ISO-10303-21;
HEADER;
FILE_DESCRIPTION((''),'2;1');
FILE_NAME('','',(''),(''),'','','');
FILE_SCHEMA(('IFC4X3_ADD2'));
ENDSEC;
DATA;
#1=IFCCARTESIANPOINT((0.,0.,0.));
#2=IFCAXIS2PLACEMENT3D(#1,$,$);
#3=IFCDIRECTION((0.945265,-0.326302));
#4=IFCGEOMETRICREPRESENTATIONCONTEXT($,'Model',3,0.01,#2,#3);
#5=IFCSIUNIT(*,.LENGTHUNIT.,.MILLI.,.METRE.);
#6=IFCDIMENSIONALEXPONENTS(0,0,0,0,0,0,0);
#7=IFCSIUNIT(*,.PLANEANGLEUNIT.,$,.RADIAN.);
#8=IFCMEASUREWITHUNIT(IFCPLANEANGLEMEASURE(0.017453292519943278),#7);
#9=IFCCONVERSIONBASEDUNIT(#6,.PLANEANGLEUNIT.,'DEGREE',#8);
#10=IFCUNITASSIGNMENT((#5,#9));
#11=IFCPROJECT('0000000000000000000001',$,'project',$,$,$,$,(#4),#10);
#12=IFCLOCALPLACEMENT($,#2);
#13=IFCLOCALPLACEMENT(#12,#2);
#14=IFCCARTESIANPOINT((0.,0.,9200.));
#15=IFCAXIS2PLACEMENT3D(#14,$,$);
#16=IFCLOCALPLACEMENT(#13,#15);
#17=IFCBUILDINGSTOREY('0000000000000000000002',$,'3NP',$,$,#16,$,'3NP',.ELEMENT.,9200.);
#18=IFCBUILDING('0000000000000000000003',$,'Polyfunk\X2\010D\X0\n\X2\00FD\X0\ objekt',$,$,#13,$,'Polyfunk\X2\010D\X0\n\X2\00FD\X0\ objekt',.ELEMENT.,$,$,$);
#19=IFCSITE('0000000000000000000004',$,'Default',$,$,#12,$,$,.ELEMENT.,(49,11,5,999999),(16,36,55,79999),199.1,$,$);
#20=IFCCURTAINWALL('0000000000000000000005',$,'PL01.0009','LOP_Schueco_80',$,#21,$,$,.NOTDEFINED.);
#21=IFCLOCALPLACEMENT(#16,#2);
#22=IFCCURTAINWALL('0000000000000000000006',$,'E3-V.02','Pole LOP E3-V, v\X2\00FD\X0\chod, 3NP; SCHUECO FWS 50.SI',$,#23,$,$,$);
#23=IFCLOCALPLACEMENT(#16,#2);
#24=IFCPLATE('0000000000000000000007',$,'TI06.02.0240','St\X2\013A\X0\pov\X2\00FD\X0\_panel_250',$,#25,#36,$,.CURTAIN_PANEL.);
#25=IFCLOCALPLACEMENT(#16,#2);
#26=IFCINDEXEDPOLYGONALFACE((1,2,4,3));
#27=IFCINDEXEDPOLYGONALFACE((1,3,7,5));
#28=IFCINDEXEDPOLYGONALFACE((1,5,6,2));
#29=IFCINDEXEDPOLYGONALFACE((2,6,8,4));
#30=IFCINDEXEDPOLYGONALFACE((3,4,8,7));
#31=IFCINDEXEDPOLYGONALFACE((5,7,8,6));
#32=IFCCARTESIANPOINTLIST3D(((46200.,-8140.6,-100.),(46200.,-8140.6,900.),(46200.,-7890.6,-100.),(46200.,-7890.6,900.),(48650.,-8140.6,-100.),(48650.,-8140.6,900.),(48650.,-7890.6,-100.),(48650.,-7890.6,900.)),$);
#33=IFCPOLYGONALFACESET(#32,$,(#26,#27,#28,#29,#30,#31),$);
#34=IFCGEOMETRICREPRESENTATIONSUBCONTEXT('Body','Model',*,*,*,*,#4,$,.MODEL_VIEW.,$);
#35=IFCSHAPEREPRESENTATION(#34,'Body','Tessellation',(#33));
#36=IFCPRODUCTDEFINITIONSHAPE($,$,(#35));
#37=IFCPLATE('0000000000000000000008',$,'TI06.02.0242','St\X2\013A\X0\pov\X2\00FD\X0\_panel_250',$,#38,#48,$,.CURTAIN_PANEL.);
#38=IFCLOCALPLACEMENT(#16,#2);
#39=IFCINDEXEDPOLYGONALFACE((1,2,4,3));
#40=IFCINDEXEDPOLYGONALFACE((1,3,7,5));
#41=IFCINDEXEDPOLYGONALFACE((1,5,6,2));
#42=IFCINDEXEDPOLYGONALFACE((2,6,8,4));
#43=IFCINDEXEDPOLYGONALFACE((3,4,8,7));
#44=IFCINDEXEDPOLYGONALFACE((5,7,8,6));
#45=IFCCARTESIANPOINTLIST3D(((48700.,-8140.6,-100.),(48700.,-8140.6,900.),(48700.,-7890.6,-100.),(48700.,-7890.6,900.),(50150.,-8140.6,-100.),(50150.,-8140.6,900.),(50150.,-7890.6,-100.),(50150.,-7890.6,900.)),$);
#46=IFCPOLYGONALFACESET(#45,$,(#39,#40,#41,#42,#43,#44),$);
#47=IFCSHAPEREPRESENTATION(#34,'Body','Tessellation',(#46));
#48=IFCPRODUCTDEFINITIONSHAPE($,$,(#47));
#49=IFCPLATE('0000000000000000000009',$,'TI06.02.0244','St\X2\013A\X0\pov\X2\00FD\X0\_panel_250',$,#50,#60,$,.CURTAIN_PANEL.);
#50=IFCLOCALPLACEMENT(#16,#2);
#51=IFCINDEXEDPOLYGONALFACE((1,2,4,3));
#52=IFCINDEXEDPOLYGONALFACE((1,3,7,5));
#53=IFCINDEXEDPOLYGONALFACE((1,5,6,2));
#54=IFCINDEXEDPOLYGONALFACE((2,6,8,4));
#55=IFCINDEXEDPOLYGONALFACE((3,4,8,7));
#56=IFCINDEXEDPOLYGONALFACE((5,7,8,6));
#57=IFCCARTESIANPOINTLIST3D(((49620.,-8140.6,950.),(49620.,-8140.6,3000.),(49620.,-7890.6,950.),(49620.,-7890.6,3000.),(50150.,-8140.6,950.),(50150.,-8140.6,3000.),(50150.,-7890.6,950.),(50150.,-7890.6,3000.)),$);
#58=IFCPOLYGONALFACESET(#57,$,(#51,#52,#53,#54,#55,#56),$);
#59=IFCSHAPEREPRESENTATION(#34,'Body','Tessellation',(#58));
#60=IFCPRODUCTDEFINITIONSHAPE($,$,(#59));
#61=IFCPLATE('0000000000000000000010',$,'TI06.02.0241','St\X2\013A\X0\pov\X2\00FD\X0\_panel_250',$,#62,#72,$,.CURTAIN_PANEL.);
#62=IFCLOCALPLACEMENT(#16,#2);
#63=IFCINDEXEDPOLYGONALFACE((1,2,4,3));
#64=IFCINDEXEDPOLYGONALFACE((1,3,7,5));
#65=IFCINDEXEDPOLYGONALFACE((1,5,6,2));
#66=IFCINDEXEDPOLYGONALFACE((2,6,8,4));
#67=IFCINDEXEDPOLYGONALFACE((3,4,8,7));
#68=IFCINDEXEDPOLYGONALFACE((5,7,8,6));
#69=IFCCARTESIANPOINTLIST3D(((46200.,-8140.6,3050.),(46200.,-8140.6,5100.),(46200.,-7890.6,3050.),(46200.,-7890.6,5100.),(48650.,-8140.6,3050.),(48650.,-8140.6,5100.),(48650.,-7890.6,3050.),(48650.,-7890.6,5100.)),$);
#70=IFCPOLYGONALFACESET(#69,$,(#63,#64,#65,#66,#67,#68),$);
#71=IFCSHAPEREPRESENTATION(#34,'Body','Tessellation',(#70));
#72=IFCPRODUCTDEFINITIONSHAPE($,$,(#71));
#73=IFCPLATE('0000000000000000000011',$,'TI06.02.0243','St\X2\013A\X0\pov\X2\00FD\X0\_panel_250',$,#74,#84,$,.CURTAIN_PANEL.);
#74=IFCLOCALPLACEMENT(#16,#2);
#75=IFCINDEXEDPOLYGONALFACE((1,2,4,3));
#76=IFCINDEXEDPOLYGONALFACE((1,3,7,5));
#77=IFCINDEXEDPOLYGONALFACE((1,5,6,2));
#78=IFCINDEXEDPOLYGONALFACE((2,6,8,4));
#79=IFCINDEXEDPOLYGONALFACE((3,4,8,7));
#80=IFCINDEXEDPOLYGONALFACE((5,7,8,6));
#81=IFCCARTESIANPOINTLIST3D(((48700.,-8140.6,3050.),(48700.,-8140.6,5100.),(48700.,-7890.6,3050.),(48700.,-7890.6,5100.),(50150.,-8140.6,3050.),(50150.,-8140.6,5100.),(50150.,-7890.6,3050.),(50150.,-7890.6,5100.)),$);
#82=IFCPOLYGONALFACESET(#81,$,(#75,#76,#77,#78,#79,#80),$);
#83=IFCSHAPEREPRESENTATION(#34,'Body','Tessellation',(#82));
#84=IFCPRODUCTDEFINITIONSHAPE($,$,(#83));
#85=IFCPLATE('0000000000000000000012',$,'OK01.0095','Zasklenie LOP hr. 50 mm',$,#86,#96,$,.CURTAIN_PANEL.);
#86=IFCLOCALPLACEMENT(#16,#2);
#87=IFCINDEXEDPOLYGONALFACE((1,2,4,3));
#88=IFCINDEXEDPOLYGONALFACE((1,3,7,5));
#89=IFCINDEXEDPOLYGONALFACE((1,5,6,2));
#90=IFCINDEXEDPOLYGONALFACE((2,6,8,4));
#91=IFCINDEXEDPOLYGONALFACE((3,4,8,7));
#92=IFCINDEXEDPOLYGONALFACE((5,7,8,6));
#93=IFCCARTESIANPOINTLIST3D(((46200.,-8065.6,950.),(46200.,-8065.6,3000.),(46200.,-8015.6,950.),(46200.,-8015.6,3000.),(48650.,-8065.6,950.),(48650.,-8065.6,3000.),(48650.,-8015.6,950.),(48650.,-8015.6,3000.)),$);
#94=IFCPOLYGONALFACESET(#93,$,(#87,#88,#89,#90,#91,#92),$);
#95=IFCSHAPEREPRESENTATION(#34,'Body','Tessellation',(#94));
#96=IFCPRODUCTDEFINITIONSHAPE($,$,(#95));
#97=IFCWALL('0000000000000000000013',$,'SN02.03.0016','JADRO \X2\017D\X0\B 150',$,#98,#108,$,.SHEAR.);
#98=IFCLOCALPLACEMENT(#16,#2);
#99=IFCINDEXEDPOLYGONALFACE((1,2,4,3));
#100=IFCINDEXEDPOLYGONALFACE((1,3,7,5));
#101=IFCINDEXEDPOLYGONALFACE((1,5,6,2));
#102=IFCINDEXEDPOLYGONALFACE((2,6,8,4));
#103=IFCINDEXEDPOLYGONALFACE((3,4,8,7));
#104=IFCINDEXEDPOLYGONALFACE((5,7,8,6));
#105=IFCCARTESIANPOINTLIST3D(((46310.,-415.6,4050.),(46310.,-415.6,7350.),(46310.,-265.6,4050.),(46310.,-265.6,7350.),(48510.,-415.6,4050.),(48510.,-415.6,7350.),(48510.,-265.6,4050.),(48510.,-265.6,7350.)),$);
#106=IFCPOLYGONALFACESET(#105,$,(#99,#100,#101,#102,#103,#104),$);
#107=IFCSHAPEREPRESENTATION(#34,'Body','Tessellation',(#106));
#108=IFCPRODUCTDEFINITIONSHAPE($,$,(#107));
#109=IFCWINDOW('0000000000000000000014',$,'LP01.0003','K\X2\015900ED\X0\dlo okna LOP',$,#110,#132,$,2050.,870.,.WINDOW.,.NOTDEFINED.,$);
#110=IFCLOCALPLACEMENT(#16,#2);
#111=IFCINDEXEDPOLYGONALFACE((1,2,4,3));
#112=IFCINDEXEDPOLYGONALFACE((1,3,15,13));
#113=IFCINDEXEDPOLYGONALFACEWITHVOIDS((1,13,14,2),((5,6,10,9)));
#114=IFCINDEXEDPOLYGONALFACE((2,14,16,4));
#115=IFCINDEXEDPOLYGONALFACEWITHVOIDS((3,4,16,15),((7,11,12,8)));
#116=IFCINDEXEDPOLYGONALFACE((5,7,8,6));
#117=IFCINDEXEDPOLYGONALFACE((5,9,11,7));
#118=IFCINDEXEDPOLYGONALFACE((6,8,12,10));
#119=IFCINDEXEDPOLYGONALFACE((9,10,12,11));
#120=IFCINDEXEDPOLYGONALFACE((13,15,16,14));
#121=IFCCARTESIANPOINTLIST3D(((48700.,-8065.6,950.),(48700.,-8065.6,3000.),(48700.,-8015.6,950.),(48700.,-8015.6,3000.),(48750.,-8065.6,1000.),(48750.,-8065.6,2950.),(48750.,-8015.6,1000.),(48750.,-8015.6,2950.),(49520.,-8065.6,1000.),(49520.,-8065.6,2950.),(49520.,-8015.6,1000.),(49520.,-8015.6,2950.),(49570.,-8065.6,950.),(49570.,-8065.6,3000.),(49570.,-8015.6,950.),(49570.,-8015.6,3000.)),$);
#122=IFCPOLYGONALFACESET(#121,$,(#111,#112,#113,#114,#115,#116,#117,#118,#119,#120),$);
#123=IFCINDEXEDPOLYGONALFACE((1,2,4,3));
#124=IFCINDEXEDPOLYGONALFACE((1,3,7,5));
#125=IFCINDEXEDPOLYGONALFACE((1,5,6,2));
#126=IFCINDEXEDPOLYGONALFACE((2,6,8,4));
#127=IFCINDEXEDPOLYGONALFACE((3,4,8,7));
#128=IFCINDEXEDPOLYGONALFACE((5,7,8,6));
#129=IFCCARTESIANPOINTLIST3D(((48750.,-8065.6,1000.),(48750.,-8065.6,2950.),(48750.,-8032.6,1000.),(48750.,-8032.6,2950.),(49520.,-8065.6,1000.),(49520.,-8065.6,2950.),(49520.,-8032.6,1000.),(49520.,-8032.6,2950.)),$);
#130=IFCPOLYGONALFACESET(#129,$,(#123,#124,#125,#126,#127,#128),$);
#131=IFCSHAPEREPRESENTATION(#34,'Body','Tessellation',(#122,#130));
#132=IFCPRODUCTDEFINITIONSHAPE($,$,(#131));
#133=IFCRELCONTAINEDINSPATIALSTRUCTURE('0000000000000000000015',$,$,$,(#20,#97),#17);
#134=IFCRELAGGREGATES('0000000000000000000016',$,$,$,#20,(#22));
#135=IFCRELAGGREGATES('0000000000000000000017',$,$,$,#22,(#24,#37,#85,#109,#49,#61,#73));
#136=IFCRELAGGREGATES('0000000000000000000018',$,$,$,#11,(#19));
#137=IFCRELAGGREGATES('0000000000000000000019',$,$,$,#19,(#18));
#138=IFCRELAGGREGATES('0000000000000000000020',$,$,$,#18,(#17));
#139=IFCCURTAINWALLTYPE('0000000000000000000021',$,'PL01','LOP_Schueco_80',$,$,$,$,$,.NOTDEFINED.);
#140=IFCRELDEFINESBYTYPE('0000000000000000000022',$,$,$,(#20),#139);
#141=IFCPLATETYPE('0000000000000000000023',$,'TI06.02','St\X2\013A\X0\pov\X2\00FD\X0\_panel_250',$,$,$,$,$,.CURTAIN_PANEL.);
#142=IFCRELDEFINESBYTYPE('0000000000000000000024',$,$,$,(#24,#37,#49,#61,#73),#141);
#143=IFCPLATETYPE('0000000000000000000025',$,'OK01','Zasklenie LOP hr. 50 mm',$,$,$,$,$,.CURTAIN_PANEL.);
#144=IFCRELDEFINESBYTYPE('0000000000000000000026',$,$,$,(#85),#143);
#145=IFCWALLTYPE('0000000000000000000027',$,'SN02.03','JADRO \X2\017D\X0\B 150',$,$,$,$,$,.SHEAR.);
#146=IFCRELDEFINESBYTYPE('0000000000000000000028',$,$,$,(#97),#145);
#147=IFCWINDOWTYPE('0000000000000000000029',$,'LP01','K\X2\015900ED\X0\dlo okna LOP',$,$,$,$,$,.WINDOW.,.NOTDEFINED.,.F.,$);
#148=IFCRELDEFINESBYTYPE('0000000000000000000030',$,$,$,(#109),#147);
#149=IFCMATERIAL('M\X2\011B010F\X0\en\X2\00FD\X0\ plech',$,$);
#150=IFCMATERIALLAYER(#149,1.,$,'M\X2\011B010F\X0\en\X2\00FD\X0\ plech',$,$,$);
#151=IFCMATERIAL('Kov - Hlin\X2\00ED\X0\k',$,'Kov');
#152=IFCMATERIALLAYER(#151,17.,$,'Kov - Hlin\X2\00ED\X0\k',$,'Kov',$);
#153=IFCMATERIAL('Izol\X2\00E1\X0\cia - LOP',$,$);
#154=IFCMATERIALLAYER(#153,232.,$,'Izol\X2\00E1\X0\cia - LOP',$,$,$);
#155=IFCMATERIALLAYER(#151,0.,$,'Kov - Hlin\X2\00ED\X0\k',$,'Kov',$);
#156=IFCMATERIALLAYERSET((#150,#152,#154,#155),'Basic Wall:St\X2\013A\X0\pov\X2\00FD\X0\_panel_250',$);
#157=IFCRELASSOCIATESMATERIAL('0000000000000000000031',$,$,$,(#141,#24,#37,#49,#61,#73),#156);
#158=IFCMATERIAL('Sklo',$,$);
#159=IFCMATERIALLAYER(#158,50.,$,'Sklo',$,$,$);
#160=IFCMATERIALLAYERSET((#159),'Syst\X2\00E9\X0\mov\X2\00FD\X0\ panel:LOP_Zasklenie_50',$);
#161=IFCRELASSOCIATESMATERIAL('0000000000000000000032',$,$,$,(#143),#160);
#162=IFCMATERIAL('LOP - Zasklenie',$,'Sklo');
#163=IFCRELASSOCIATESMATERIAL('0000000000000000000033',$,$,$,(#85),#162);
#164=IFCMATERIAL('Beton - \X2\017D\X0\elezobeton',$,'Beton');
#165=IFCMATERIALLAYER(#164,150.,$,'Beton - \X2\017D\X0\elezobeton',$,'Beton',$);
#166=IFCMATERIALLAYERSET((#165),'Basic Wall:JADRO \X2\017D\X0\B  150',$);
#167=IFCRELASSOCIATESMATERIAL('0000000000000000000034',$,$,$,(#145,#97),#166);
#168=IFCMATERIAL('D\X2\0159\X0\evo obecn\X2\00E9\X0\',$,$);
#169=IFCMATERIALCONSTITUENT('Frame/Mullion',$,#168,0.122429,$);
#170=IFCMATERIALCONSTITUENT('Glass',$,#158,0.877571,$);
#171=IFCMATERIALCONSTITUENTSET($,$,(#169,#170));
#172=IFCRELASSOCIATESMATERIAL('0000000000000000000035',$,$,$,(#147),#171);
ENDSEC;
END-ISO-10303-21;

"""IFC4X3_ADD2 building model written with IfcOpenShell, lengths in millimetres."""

from ifc_helpers import new_model, entity, si_unit, converted_unit, direction, frame, frame_2d, origin, origin_2d_with_axis, place, context, subcontext, project, spatial, polyline, rectangle, outline, extrude, clip, bounded_halfspace, source, transform, mapped, material, layer, layer_set, layer_usage, constituent, constituent_set, type_object, type_shapes, element, aggregate, save


model = new_model("IFC4X3_ADD2")

# Units and contexts
model_context = context("Model", 3, precision=0.01, world=origin(), true_north=direction((0.945265, -0.326302)))
body_context = subcontext(model_context, "Body", "Model", "MODEL_VIEW")
ifc_project = project(units=[si_unit("LENGTHUNIT", "METRE", prefix="MILLI"), converted_unit("PLANEANGLEUNIT", "DEGREE", entity("IfcPlaneAngleMeasure", 0.017453292519943278), si_unit("PLANEANGLEUNIT", "RADIAN"), dimensions=[0, 0, 0, 0, 0, 0, 0])], contexts=[model_context])

# Site, building, storey
site_placement = place(None, origin())
site = spatial("IfcSite", under=ifc_project, at=site_placement, Name="Default", CompositionType="ELEMENT", RefLatitude=(49, 11, 5, 999999), RefLongitude=(16, 36, 55, 79999), RefElevation=199.1)
building_placement = place(site_placement, origin())
building = spatial("IfcBuilding", under=site, at=building_placement, Name="Polyfunkčný objekt", LongName="Polyfunkčný objekt", CompositionType="ELEMENT")
storey_placement = place(building_placement, frame((0.0, 0.0, 9200.0)))
storey = spatial("IfcBuildingStorey", under=building, at=storey_placement, Name="3NP", LongName="3NP", CompositionType="ELEMENT", Elevation=9200.0)

# Curtain walls, plates
curtain_wall_type = type_object("IfcCurtainWallType", Name="PL01", Description="LOP_Schueco_80", PredefinedType="NOTDEFINED")
curtain_wall_1_placement = place(storey_placement, frame((0.0, 0.0, -9200.0)))
curtain_wall_1 = element("IfcCurtainWall", 1, at=curtain_wall_1_placement, inside=storey, type_object=curtain_wall_type, Name="PL01.0009", Description="LOP_Schueco_80", PredefinedType="NOTDEFINED")
curtain_wall_2 = element("IfcCurtainWall", 2, Name="E3-V.02", Description="Pole LOP E3-V, východ, 3NP; SCHUECO FWS 50.SI")
aggregate(curtain_wall_1, [curtain_wall_2])
ifc_material_1 = material(Name="Měďený plech")
ifc_layer_1 = layer(ifc_material_1, 1.0, Name="Měďený plech")
ifc_material_2 = material(Name="Kov - Hliník", Category="Kov")
ifc_layer_2 = layer(ifc_material_2, 17.0, Name="Kov - Hliník", Category="Kov")
ifc_material_3 = material(Name="Izolácia - LOP")
ifc_layer_3 = layer(ifc_material_3, 232.0, Name="Izolácia - LOP")
ifc_layer_4 = layer(ifc_material_2, 0.0, Name="Kov - Hliník", Category="Kov")
ifc_layer_set_1 = layer_set([ifc_layer_1, ifc_layer_2, ifc_layer_3, ifc_layer_4], Name="Basic Wall:Stĺpový_panel_250")
ifc_layer_usage_1 = layer_usage(ifc_layer_set_1, "AXIS2", "POSITIVE", -125.0)
plate_type_1 = type_object("IfcPlateType", Name="TI06.02", Description="Stĺpový_panel_250", PredefinedType="CURTAIN_PANEL", material=ifc_layer_set_1)
plate_1_placement = place(storey_placement, frame((46200.0, -8015.6, -100.0)))
plate_1 = element("IfcPlate", 3, at=plate_1_placement, type_object=plate_type_1, material=ifc_layer_usage_1, Name="TI06.02.0240", Description="Stĺpový_panel_250", PredefinedType="CURTAIN_PANEL", context=body_context, shape_type="SweptSolid", body=[
    extrude(rectangle(XDim=250.0, YDim=2450.0, at=frame_2d((0.0, 0.0), x_axis=(1.0, 0.0))), frame((1225.0, 0.0, 0.0), z_axis=(0.0, 0.0, 1.0), x_axis=(0.0, 1.0, 0.0)), (0.0, 0.0, 1.0), 1000.0),
])
ifc_layer_usage_2 = layer_usage(ifc_layer_set_1, "AXIS2", "POSITIVE", -125.0)
plate_2_placement = place(storey_placement, frame((48700.0, -8015.6, -100.0)))
plate_2 = element("IfcPlate", 4, at=plate_2_placement, type_object=plate_type_1, material=ifc_layer_usage_2, Name="TI06.02.0242", Description="Stĺpový_panel_250", PredefinedType="CURTAIN_PANEL", context=body_context, shape_type="SweptSolid", body=[
    extrude(rectangle(XDim=250.0, YDim=1450.0, at=frame_2d((0.0, 0.0), x_axis=(1.0, 0.0))), frame((725.0, 0.0, 0.0), z_axis=(0.0, 0.0, 1.0), x_axis=(0.0, 1.0, 0.0)), (0.0, 0.0, 1.0), 1000.0),
])
ifc_layer_usage_3 = layer_usage(ifc_layer_set_1, "AXIS2", "POSITIVE", -125.0)
plate_3_placement = place(storey_placement, frame((49620.0, -8015.6, 950.0)))
plate_3 = element("IfcPlate", 5, at=plate_3_placement, type_object=plate_type_1, material=ifc_layer_usage_3, Name="TI06.02.0244", Description="Stĺpový_panel_250", PredefinedType="CURTAIN_PANEL", context=body_context, shape_type="SweptSolid", body=[
    extrude(rectangle(XDim=250.0, YDim=530.0, at=origin_2d_with_axis()), frame((265.0, 0.0, 0.0), z_axis=(0.0, 0.0, 1.0), x_axis=(0.0, 1.0, 0.0)), (0.0, 0.0, 1.0), 2050.0),
])
ifc_layer_usage_4 = layer_usage(ifc_layer_set_1, "AXIS2", "POSITIVE", -125.0)
plate_4_placement = place(storey_placement, frame((46200.0, -8015.6, 3050.0)))
plate_4 = element("IfcPlate", 6, at=plate_4_placement, type_object=plate_type_1, material=ifc_layer_usage_4, Name="TI06.02.0241", Description="Stĺpový_panel_250", PredefinedType="CURTAIN_PANEL", context=body_context, shape_type="SweptSolid", body=[
    extrude(rectangle(XDim=250.0, YDim=2450.0, at=frame_2d((0.0, 0.0), x_axis=(1.0, 0.0))), frame((1225.0, 0.0, 0.0), z_axis=(0.0, 0.0, 1.0), x_axis=(0.0, 1.0, 0.0)), (0.0, 0.0, 1.0), 2050.0),
])
ifc_layer_usage_5 = layer_usage(ifc_layer_set_1, "AXIS2", "POSITIVE", -125.0)
plate_5_placement = place(storey_placement, frame((48700.0, -8015.6, 3050.0)))
plate_5 = element("IfcPlate", 7, at=plate_5_placement, type_object=plate_type_1, material=ifc_layer_usage_5, Name="TI06.02.0243", Description="Stĺpový_panel_250", PredefinedType="CURTAIN_PANEL", context=body_context, shape_type="SweptSolid", body=[
    extrude(rectangle(XDim=250.0, YDim=1450.0, at=frame_2d((0.0, 0.0), x_axis=(1.0, 0.0))), frame((725.0, 0.0, 0.0), z_axis=(0.0, 0.0, 1.0), x_axis=(0.0, 1.0, 0.0)), (0.0, 0.0, 1.0), 2050.0),
])
ifc_material_4 = material(Name="LOP - Zasklenie", Category="Sklo")
ifc_material_5 = material(Name="Sklo")
ifc_layer_5 = layer(ifc_material_5, 50.0, Name="Sklo")
ifc_layer_set_2 = layer_set([ifc_layer_5], Name="Systémový panel:LOP_Zasklenie_50")
plate_type_2 = type_object("IfcPlateType", Name="OK01", Description="Zasklenie LOP hr. 50 mm", PredefinedType="CURTAIN_PANEL", material=ifc_layer_set_2)
shared_shape_1 = source(origin(), body_context, "Body", "SweptSolid", [
    extrude(rectangle(XDim=50.0, YDim=2450.0, at=origin_2d_with_axis()), frame((0.0, -25.0, 0.0), z_axis=(0.0, 0.0, 1.0), x_axis=(0.0, 1.0, 0.0)), (0.0, 0.0, 1.0), 2050.0),
])
type_shapes(plate_type_2, [shared_shape_1])
plate_6_placement = place(curtain_wall_1_placement, frame((47425.0, -8015.6, 10150.0)))
plate_6 = element("IfcPlate", 8, at=plate_6_placement, type_object=plate_type_2, material=ifc_material_4, Name="OK01.0095", Description="Zasklenie LOP hr. 50 mm", PredefinedType="CURTAIN_PANEL", context=body_context, shape_type="MappedRepresentation", body=[
    mapped(shared_shape_1, transform((0.0, 0.0, 0.0), scale=1.0)),
])

# Wall
ifc_material_6 = material(Name="Beton - Železobeton", Category="Beton")
ifc_layer_6 = layer(ifc_material_6, 150.0, Name="Beton - Železobeton", Category="Beton")
ifc_layer_set_3 = layer_set([ifc_layer_6], Name="Basic Wall:JADRO ŽB  150")
wall_type = type_object("IfcWallType", Name="SN02.03", Description="JADRO ŽB 150", PredefinedType="SHEAR", material=ifc_layer_set_3)
wall_placement = place(storey_placement, frame((46310.0, -340.6, 4050.0)))
element("IfcWall", 9, at=wall_placement, inside=storey, type_object=wall_type, material=ifc_layer_set_3, Name="SN02.03.0016", Description="JADRO ŽB 150", PredefinedType="SHEAR", context=body_context, shape_type="Clipping", body=[
    clip(extrude(rectangle(XDim=2200.0, YDim=150.0, at=frame_2d((1100.0, 0.0), x_axis=(-1.0, 0.0))), origin(), (0.0, 0.0, 1.0), 3300.0), bounded_halfspace(frame((2200.0, -75.0, 0.0), z_axis=(0.0, 0.0, 1.0), x_axis=(-1.0, 0.0, 0.0)), True, frame((2200.0, -75.0, 0.0)), polyline([(0.0, 0.0), (0.0, 150.0), (-2200.0, 150.0), (-2200.0, 0.0), (-150.0, 0.0), (0.0, 0.0)]))),
])

# Window
ifc_material_7 = material(Name="Dřevo obecné")
ifc_constituent_1 = constituent(ifc_material_7, Name="Frame/Mullion", fraction=0.122429)
ifc_constituent_2 = constituent(ifc_material_5, Name="Glass", fraction=0.877571)
ifc_constituent_set = constituent_set(constituents=[ifc_constituent_1, ifc_constituent_2])
window_type = type_object("IfcWindowType", Name="LP01", Description="Křídlo okna LOP", ParameterTakesPrecedence=False, PartitioningType="NOTDEFINED", PredefinedType="WINDOW", material=ifc_constituent_set)
shared_shape_2 = source(origin(), body_context, "Body", "SweptSolid", [
    extrude(outline(polyline([(-1025.0, -435.0), (1025.0, -435.0), (1025.0, 435.0), (-1025.0, 435.0), (-1025.0, -435.0)]), holes=[polyline([(-975.0, -385.0), (-975.0, 385.0), (975.0, 385.0), (975.0, -385.0), (-975.0, -385.0)])]), frame((0.0, 50.0, 1025.0), z_axis=(0.0, -1.0, 0.0), x_axis=(0.0, 0.0, -1.0)), (0.0, 0.0, 1.0), 50.0),
    extrude(rectangle(XDim=770.0, YDim=33.0, at=frame_2d((0.0, 0.0), x_axis=(1.0, 0.0))), frame((0.0, 33.5, 50.0), z_axis=(0.0, 0.0, 1.0), x_axis=(-1.0, 0.0, 0.0)), (0.0, 0.0, 1.0), 1950.0),
])
type_shapes(window_type, [shared_shape_2])
window_placement = place(curtain_wall_1_placement, frame((49135.0, -8015.6, 10150.0), z_axis=(0.0, 0.0, 1.0), x_axis=(-1.0, 0.0, 0.0)))
window = element("IfcWindow", 10, at=window_placement, type_object=window_type, Name="LP01.0003", Description="Křídlo okna LOP", OverallHeight=2050.0, OverallWidth=870.0, PartitioningType="NOTDEFINED", PredefinedType="WINDOW", context=body_context, shape_type="MappedRepresentation", body=[
    mapped(shared_shape_2, transform((0.0, 0.0, 0.0), scale=1.0)),
])
aggregate(curtain_wall_2, [plate_1, plate_2, plate_6, window, plate_3, plate_4, plate_5])

save(model, "model.ifc")
